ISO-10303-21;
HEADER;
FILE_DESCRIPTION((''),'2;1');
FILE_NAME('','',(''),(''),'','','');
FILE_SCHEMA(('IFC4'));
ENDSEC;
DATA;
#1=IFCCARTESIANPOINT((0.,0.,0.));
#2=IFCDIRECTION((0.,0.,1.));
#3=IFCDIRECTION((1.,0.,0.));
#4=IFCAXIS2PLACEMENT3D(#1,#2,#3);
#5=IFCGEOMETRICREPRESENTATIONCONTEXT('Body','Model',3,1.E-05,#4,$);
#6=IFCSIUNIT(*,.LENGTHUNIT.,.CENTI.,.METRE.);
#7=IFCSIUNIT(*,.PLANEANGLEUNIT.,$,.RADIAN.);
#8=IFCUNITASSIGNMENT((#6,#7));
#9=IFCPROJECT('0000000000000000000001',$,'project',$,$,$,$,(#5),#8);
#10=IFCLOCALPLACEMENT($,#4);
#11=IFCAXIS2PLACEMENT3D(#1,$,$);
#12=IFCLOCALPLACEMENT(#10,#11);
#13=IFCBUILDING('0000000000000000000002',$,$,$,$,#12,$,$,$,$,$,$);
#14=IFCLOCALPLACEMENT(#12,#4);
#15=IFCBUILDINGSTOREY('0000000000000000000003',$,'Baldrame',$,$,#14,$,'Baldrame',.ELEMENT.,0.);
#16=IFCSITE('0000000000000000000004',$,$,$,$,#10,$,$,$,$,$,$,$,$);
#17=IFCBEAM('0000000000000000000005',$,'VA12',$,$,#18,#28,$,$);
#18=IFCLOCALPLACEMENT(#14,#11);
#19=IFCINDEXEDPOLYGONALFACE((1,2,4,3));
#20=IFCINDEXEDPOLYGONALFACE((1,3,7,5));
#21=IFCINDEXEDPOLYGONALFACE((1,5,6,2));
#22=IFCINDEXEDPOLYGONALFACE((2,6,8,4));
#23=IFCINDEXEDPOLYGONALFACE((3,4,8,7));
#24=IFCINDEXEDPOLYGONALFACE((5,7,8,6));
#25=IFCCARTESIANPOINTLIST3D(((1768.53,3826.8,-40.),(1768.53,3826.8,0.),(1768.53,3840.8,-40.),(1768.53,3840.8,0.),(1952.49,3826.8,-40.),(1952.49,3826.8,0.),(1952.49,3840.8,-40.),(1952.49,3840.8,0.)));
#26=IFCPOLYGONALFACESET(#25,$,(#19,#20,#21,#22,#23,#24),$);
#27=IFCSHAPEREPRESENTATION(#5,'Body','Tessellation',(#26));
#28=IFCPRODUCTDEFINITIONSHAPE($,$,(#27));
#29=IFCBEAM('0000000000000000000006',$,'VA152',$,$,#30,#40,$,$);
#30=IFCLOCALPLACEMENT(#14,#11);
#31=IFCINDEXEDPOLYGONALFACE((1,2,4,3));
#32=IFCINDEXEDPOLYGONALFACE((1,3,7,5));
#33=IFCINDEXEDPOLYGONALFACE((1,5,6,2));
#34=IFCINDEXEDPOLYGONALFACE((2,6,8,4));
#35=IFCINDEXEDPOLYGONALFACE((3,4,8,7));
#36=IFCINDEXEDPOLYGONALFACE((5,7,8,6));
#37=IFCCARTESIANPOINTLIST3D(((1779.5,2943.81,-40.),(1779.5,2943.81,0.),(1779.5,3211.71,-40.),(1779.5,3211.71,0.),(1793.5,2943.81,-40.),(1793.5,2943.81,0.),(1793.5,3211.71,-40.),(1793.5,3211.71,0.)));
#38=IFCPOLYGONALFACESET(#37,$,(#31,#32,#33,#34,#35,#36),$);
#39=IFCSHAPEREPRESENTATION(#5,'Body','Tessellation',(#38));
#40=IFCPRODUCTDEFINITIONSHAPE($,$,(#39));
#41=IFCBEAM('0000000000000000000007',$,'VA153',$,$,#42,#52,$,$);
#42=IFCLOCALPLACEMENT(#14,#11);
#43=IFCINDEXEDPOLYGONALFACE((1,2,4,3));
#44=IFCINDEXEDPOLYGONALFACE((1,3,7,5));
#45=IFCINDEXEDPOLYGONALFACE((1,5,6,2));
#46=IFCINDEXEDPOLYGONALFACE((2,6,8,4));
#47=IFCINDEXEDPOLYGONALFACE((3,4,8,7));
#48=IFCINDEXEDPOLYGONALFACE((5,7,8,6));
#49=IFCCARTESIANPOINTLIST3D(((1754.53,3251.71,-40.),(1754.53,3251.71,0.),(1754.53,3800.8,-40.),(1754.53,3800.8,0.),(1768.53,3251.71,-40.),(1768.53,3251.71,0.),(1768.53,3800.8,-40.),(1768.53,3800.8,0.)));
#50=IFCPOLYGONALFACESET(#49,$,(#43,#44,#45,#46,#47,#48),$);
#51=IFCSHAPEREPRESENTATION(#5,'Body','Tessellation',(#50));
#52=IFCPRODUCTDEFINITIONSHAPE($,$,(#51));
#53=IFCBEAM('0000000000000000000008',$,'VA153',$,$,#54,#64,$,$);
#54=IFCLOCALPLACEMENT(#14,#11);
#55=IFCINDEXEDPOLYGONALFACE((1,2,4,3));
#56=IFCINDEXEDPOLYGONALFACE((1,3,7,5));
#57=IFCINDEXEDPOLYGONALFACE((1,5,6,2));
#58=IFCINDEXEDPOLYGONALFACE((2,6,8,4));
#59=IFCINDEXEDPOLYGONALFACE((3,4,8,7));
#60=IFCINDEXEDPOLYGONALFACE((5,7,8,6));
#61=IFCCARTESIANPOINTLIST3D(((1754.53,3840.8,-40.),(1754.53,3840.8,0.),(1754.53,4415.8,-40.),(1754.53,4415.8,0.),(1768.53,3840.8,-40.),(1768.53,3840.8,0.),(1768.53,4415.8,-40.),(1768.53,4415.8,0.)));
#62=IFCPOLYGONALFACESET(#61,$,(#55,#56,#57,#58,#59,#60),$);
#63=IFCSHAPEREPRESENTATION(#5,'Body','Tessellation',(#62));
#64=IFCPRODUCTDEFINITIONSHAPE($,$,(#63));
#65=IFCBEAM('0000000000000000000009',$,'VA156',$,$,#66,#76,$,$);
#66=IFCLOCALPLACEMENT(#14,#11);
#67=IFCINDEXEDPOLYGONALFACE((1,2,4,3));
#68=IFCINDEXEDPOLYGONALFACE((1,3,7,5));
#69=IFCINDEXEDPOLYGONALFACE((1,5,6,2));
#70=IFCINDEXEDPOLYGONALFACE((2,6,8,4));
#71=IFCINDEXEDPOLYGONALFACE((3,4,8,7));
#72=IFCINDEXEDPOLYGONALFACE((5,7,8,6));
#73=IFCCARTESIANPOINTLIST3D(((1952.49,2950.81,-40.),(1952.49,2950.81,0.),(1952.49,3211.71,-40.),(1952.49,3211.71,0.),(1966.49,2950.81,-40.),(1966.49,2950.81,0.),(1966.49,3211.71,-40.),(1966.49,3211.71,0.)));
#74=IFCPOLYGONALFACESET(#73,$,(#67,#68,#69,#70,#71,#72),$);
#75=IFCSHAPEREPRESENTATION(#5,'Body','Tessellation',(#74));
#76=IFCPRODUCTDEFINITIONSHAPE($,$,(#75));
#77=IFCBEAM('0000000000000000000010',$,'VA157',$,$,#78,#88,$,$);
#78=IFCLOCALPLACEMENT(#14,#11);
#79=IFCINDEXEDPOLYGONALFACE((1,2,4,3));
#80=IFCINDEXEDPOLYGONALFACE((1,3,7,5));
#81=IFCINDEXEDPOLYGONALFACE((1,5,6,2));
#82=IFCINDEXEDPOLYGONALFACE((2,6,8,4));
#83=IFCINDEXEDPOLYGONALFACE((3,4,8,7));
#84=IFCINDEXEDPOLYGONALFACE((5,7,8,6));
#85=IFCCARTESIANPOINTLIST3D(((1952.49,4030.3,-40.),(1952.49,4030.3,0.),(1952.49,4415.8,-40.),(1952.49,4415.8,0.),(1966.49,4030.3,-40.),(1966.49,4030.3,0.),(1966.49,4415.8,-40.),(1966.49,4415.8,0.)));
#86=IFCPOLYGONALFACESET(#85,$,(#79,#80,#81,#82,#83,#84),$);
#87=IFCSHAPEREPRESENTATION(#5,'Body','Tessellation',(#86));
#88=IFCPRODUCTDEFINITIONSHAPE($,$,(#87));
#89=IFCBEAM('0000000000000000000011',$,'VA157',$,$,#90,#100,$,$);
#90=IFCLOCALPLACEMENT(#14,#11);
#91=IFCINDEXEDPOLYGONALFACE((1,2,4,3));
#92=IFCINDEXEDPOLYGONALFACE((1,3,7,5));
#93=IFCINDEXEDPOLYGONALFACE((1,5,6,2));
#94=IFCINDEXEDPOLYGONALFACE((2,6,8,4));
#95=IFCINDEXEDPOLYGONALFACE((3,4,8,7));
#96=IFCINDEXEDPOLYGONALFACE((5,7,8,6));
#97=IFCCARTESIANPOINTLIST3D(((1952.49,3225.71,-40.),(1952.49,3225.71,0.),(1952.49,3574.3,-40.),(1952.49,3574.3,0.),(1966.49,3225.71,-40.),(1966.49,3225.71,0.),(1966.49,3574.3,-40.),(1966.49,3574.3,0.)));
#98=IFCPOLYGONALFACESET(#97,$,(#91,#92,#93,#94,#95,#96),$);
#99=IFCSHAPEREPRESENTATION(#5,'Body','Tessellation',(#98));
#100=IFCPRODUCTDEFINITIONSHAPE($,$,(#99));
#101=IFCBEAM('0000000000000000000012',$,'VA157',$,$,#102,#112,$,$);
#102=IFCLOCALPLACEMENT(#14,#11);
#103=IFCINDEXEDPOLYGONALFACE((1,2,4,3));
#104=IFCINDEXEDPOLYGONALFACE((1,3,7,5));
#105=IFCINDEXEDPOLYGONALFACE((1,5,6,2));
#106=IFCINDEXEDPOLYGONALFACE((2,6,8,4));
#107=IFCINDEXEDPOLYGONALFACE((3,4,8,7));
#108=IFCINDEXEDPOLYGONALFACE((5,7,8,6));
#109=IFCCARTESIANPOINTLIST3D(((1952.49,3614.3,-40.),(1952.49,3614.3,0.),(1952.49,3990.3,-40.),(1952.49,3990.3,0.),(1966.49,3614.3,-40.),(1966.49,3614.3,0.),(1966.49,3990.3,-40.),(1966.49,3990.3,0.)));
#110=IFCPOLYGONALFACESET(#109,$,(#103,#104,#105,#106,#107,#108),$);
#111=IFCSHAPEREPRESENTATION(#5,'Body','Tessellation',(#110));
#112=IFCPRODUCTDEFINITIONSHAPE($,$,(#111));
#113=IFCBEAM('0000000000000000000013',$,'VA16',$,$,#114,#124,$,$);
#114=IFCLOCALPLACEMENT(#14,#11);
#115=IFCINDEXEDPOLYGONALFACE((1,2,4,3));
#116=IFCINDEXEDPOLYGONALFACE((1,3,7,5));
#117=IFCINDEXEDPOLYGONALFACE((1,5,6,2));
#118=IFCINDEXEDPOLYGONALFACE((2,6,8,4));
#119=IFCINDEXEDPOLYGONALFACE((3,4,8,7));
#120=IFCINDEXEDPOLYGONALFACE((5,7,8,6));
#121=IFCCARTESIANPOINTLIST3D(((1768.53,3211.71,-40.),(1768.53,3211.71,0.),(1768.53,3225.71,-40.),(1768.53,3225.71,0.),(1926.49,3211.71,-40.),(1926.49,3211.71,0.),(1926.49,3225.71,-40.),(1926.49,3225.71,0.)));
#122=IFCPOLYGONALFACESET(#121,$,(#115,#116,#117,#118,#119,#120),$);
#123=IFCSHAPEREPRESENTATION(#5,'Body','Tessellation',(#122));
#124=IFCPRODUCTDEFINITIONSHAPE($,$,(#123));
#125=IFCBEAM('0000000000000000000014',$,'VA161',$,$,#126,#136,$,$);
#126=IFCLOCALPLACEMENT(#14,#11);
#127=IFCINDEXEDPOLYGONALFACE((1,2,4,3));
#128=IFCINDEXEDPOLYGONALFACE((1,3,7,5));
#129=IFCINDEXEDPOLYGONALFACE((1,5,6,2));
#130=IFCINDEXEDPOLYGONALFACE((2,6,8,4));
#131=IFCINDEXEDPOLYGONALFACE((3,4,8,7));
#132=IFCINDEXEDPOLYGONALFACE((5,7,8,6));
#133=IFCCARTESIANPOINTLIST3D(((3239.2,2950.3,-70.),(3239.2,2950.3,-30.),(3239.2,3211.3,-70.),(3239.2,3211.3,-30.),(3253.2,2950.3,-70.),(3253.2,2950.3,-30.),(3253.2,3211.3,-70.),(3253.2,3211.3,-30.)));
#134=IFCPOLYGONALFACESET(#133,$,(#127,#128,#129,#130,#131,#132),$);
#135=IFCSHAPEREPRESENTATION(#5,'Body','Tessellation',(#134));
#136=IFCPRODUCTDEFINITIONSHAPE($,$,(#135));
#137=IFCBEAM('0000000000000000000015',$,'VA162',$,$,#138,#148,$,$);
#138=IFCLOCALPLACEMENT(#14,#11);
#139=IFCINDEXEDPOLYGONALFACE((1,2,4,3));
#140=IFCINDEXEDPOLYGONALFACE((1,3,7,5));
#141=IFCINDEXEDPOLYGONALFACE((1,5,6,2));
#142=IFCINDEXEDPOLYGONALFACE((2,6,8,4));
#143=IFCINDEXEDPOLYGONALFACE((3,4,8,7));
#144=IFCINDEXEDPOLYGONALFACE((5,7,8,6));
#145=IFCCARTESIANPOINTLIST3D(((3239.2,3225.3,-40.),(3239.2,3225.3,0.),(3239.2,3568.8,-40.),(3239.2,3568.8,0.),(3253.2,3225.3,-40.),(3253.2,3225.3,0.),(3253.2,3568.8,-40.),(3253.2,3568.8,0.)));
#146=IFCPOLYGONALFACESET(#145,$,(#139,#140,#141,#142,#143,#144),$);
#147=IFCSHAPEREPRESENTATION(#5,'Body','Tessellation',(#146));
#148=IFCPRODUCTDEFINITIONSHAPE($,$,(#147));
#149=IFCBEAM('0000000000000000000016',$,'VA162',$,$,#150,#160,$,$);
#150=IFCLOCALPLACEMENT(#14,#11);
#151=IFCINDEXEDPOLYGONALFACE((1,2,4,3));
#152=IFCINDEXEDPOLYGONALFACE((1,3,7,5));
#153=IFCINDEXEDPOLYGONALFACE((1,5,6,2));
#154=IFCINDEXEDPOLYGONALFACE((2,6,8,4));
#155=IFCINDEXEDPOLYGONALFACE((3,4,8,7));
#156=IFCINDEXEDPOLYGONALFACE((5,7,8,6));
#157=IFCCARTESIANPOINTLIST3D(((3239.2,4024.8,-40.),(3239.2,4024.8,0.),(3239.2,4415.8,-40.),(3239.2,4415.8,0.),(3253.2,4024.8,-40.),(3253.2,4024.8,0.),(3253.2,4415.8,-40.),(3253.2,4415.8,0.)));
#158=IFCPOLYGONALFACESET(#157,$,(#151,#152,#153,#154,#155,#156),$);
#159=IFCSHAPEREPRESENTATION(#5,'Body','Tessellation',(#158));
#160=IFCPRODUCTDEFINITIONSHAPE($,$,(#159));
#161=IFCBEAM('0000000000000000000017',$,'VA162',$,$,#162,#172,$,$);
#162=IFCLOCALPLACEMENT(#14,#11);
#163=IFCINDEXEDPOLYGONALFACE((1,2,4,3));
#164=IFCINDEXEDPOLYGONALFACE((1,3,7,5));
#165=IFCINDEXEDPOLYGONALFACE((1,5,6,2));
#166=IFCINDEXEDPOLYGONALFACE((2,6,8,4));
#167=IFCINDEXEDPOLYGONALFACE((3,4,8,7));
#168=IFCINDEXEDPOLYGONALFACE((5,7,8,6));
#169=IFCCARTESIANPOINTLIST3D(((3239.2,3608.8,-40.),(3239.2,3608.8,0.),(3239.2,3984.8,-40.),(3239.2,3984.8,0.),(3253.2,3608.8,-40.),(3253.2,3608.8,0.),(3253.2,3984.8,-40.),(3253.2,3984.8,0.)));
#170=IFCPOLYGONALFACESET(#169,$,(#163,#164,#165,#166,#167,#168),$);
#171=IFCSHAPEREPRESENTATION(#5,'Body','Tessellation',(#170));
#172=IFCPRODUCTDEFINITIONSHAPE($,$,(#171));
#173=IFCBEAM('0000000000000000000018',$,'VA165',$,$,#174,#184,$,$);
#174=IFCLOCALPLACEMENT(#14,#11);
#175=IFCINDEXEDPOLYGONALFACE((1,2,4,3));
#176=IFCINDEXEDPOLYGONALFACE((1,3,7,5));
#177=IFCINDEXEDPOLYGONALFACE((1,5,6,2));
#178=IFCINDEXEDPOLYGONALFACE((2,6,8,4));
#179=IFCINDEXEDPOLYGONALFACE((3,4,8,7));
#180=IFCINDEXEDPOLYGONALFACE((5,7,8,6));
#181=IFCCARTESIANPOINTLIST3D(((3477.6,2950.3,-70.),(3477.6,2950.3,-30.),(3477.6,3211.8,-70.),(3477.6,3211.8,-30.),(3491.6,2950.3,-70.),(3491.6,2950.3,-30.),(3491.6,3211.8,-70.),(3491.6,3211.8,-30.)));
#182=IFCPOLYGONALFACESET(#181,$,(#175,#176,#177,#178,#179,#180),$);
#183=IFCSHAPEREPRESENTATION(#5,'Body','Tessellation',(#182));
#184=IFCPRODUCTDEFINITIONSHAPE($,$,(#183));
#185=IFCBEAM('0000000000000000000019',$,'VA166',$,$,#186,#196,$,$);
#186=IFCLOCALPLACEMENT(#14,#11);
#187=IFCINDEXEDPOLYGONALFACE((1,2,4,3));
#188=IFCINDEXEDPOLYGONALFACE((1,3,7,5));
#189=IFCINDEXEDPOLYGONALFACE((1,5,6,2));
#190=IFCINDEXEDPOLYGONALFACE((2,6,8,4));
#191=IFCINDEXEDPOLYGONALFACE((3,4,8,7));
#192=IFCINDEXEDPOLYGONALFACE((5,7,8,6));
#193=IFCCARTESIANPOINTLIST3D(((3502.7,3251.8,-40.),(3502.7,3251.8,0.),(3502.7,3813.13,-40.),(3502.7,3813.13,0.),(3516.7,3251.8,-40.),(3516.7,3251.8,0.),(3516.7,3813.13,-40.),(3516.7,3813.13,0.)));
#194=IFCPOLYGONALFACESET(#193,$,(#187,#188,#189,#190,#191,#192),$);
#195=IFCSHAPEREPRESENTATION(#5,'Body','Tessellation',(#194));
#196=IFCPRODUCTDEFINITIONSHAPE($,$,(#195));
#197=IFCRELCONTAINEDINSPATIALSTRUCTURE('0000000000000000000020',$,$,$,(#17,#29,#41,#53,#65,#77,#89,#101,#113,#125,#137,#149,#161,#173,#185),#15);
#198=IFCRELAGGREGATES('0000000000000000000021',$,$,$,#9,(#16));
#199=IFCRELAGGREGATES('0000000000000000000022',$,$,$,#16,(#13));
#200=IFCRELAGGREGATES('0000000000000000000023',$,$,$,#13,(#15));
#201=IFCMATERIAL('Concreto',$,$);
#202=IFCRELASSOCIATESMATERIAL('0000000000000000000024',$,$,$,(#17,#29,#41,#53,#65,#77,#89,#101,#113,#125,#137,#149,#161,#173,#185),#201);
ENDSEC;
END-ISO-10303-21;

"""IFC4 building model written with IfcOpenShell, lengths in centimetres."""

from ifc_helpers import new_model, si_unit, frame, origin, origin_with_axes, origin_2d_with_axis, place, context, project, spatial, rectangle, extrude, material, element, save


model = new_model("IFC4")

# Units and contexts
model_context = context("Model", 3, precision=1e-05, world=origin_with_axes(), identifier="Body")
ifc_project = project(units=[si_unit("LENGTHUNIT", "METRE", prefix="CENTI"), si_unit("PLANEANGLEUNIT", "RADIAN")], contexts=[model_context])

# Site, building, storey
site_placement = place(None, origin_with_axes())
site = spatial("IfcSite", under=ifc_project, at=site_placement)
building_placement = place(site_placement, origin())
building = spatial("IfcBuilding", under=site, at=building_placement)
storey_placement = place(building_placement, origin_with_axes())
storey = spatial("IfcBuildingStorey", under=building, at=storey_placement, Name="Baldrame", LongName="Baldrame", CompositionType="ELEMENT", Elevation=0.0)

# Shared definitions
ifc_material = material(Name="Concreto")

# Beams
beam_1_placement = place(storey_placement, frame((1860.51, 3833.8, 0.0), z_axis=(0.0, 0.0, 1.0), x_axis=(1.0, 0.0, 0.0)))
element("IfcBeam", 1, at=beam_1_placement, inside=storey, material=ifc_material, Name="VA12", context=model_context, shape_type="SolidModel", body=[
    extrude(rectangle(XDim=14.0, YDim=40.0, at=origin_2d_with_axis()), frame((-91.98, 0.0, -20.0), z_axis=(1.0, 0.0, 0.0), x_axis=(0.0, 1.0, 0.0)), (0.0, 0.0, 1.0), 183.96),
])
beam_2_placement = place(storey_placement, frame((1786.5, 3077.76, 0.0), z_axis=(0.0, 0.0, 1.0), x_axis=(1.0, 0.0, 0.0)))
element("IfcBeam", 2, at=beam_2_placement, inside=storey, material=ifc_material, Name="VA152", context=model_context, shape_type="SolidModel", body=[
    extrude(rectangle(XDim=14.0, YDim=40.0, at=origin_2d_with_axis()), frame((0.0, -133.95, -20.0), z_axis=(0.0, 1.0, 0.0), x_axis=(-1.0, 0.0, 0.0)), (0.0, 0.0, 1.0), 267.9),
])
beam_3_placement = place(storey_placement, frame((1761.53, 3526.26, 0.0), z_axis=(0.0, 0.0, 1.0), x_axis=(1.0, 0.0, 0.0)))
element("IfcBeam", 3, at=beam_3_placement, inside=storey, material=ifc_material, Name="VA153", context=model_context, shape_type="SolidModel", body=[
    extrude(rectangle(XDim=14.0, YDim=40.0, at=origin_2d_with_axis()), frame((0.0, -274.55, -20.0), z_axis=(0.0, 1.0, 0.0), x_axis=(-1.0, 0.0, 0.0)), (0.0, 0.0, 1.0), 549.09),
])
beam_4_placement = place(storey_placement, frame((1761.53, 4128.3, 0.0), z_axis=(0.0, 0.0, 1.0), x_axis=(1.0, 0.0, 0.0)))
element("IfcBeam", 4, at=beam_4_placement, inside=storey, material=ifc_material, Name="VA153", context=model_context, shape_type="SolidModel", body=[
    extrude(rectangle(XDim=14.0, YDim=40.0, at=origin_2d_with_axis()), frame((0.0, -287.5, -20.0), z_axis=(0.0, 1.0, 0.0), x_axis=(-1.0, 0.0, 0.0)), (0.0, 0.0, 1.0), 575.0),
])
beam_5_placement = place(storey_placement, frame((1959.49, 3081.26, 0.0), z_axis=(0.0, 0.0, 1.0), x_axis=(1.0, 0.0, 0.0)))
element("IfcBeam", 5, at=beam_5_placement, inside=storey, material=ifc_material, Name="VA156", context=model_context, shape_type="SolidModel", body=[
    extrude(rectangle(XDim=14.0, YDim=40.0, at=origin_2d_with_axis()), frame((0.0, -130.45, -20.0), z_axis=(0.0, 1.0, 0.0), x_axis=(1.0, 0.0, 0.0)), (0.0, 0.0, 1.0), 260.9),
])
beam_6_placement = place(storey_placement, frame((1959.49, 4223.05, 0.0), z_axis=(0.0, 0.0, 1.0), x_axis=(1.0, 0.0, 0.0)))
element("IfcBeam", 6, at=beam_6_placement, inside=storey, material=ifc_material, Name="VA157", context=model_context, shape_type="SolidModel", body=[
    extrude(rectangle(XDim=14.0, YDim=40.0, at=origin_2d_with_axis()), frame((0.0, -192.75, -20.0), z_axis=(0.0, 1.0, 0.0), x_axis=(-1.0, 0.0, 0.0)), (0.0, 0.0, 1.0), 385.5),
])
beam_7_placement = place(storey_placement, frame((1959.49, 3400.01, 0.0), z_axis=(0.0, 0.0, 1.0), x_axis=(1.0, 0.0, 0.0)))
element("IfcBeam", 7, at=beam_7_placement, inside=storey, material=ifc_material, Name="VA157", context=model_context, shape_type="SolidModel", body=[
    extrude(rectangle(XDim=14.0, YDim=40.0, at=origin_2d_with_axis()), frame((0.0, -174.29, -20.0), z_axis=(0.0, 1.0, 0.0), x_axis=(-1.0, 0.0, 0.0)), (0.0, 0.0, 1.0), 348.59),
])
beam_8_placement = place(storey_placement, frame((1959.49, 3802.3, 0.0), z_axis=(0.0, 0.0, 1.0), x_axis=(1.0, 0.0, 0.0)))
element("IfcBeam", 8, at=beam_8_placement, inside=storey, material=ifc_material, Name="VA157", context=model_context, shape_type="SolidModel", body=[
    extrude(rectangle(XDim=14.0, YDim=40.0, at=origin_2d_with_axis()), frame((0.0, -188.0, -20.0), z_axis=(0.0, 1.0, 0.0), x_axis=(-1.0, 0.0, 0.0)), (0.0, 0.0, 1.0), 376.0),
])
beam_9_placement = place(storey_placement, frame((1847.51, 3218.71, 0.0), z_axis=(0.0, 0.0, 1.0), x_axis=(1.0, 0.0, 0.0)))
element("IfcBeam", 9, at=beam_9_placement, inside=storey, material=ifc_material, Name="VA16", context=model_context, shape_type="SolidModel", body=[
    extrude(rectangle(XDim=14.0, YDim=40.0, at=origin_2d_with_axis()), frame((-78.98, 0.0, -20.0), z_axis=(1.0, 0.0, 0.0), x_axis=(0.0, 1.0, 0.0)), (0.0, 0.0, 1.0), 157.96),
])
beam_10_placement = place(storey_placement, frame((3246.2, 3080.8, -30.0), z_axis=(0.0, 0.0, 1.0), x_axis=(1.0, 0.0, 0.0)))
element("IfcBeam", 10, at=beam_10_placement, inside=storey, material=ifc_material, Name="VA161", context=model_context, shape_type="SolidModel", body=[
    extrude(rectangle(XDim=14.0, YDim=40.0, at=origin_2d_with_axis()), frame((0.0, -130.5, -20.0), z_axis=(0.0, 1.0, 0.0), x_axis=(1.0, 0.0, 0.0)), (0.0, 0.0, 1.0), 261.0),
])
beam_11_placement = place(storey_placement, frame((3246.2, 3397.05, 0.0), z_axis=(0.0, 0.0, 1.0), x_axis=(1.0, 0.0, 0.0)))
element("IfcBeam", 11, at=beam_11_placement, inside=storey, material=ifc_material, Name="VA162", context=model_context, shape_type="SolidModel", body=[
    extrude(rectangle(XDim=14.0, YDim=40.0, at=origin_2d_with_axis()), frame((0.0, -171.75, -20.0), z_axis=(0.0, 1.0, 0.0), x_axis=(1.0, 0.0, 0.0)), (0.0, 0.0, 1.0), 343.5),
])
beam_12_placement = place(storey_placement, frame((3246.2, 4220.3, 0.0), z_axis=(0.0, 0.0, 1.0), x_axis=(1.0, 0.0, 0.0)))
element("IfcBeam", 12, at=beam_12_placement, inside=storey, material=ifc_material, Name="VA162", context=model_context, shape_type="SolidModel", body=[
    extrude(rectangle(XDim=14.0, YDim=40.0, at=origin_2d_with_axis()), frame((0.0, -195.5, -20.0), z_axis=(0.0, 1.0, 0.0), x_axis=(1.0, 0.0, 0.0)), (0.0, 0.0, 1.0), 391.0),
])
beam_13_placement = place(storey_placement, frame((3246.2, 3796.8, 0.0), z_axis=(0.0, 0.0, 1.0), x_axis=(1.0, 0.0, 0.0)))
element("IfcBeam", 13, at=beam_13_placement, inside=storey, material=ifc_material, Name="VA162", context=model_context, shape_type="SolidModel", body=[
    extrude(rectangle(XDim=14.0, YDim=40.0, at=origin_2d_with_axis()), frame((0.0, -188.0, -20.0), z_axis=(0.0, 1.0, 0.0), x_axis=(1.0, 0.0, 0.0)), (0.0, 0.0, 1.0), 376.0),
])
beam_14_placement = place(storey_placement, frame((3484.6, 3081.05, -30.0), z_axis=(0.0, 0.0, 1.0), x_axis=(1.0, 0.0, 0.0)))
element("IfcBeam", 14, at=beam_14_placement, inside=storey, material=ifc_material, Name="VA165", context=model_context, shape_type="SolidModel", body=[
    extrude(rectangle(XDim=14.0, YDim=40.0, at=origin_2d_with_axis()), frame((0.0, -130.75, -20.0), z_axis=(0.0, 1.0, 0.0), x_axis=(1.0, 0.0, 0.0)), (0.0, 0.0, 1.0), 261.5),
])
beam_15_placement = place(storey_placement, frame((3509.7, 3532.47, 0.0), z_axis=(0.0, 0.0, 1.0), x_axis=(1.0, 0.0, 0.0)))
element("IfcBeam", 15, at=beam_15_placement, inside=storey, material=ifc_material, Name="VA166", context=model_context, shape_type="SolidModel", body=[
    extrude(rectangle(XDim=14.0, YDim=40.0, at=origin_2d_with_axis()), frame((0.0, -280.67, -20.0), z_axis=(0.0, 1.0, 0.0), x_axis=(1.0, 0.0, 0.0)), (0.0, 0.0, 1.0), 561.33),
])

save(model, "model.ifc")
